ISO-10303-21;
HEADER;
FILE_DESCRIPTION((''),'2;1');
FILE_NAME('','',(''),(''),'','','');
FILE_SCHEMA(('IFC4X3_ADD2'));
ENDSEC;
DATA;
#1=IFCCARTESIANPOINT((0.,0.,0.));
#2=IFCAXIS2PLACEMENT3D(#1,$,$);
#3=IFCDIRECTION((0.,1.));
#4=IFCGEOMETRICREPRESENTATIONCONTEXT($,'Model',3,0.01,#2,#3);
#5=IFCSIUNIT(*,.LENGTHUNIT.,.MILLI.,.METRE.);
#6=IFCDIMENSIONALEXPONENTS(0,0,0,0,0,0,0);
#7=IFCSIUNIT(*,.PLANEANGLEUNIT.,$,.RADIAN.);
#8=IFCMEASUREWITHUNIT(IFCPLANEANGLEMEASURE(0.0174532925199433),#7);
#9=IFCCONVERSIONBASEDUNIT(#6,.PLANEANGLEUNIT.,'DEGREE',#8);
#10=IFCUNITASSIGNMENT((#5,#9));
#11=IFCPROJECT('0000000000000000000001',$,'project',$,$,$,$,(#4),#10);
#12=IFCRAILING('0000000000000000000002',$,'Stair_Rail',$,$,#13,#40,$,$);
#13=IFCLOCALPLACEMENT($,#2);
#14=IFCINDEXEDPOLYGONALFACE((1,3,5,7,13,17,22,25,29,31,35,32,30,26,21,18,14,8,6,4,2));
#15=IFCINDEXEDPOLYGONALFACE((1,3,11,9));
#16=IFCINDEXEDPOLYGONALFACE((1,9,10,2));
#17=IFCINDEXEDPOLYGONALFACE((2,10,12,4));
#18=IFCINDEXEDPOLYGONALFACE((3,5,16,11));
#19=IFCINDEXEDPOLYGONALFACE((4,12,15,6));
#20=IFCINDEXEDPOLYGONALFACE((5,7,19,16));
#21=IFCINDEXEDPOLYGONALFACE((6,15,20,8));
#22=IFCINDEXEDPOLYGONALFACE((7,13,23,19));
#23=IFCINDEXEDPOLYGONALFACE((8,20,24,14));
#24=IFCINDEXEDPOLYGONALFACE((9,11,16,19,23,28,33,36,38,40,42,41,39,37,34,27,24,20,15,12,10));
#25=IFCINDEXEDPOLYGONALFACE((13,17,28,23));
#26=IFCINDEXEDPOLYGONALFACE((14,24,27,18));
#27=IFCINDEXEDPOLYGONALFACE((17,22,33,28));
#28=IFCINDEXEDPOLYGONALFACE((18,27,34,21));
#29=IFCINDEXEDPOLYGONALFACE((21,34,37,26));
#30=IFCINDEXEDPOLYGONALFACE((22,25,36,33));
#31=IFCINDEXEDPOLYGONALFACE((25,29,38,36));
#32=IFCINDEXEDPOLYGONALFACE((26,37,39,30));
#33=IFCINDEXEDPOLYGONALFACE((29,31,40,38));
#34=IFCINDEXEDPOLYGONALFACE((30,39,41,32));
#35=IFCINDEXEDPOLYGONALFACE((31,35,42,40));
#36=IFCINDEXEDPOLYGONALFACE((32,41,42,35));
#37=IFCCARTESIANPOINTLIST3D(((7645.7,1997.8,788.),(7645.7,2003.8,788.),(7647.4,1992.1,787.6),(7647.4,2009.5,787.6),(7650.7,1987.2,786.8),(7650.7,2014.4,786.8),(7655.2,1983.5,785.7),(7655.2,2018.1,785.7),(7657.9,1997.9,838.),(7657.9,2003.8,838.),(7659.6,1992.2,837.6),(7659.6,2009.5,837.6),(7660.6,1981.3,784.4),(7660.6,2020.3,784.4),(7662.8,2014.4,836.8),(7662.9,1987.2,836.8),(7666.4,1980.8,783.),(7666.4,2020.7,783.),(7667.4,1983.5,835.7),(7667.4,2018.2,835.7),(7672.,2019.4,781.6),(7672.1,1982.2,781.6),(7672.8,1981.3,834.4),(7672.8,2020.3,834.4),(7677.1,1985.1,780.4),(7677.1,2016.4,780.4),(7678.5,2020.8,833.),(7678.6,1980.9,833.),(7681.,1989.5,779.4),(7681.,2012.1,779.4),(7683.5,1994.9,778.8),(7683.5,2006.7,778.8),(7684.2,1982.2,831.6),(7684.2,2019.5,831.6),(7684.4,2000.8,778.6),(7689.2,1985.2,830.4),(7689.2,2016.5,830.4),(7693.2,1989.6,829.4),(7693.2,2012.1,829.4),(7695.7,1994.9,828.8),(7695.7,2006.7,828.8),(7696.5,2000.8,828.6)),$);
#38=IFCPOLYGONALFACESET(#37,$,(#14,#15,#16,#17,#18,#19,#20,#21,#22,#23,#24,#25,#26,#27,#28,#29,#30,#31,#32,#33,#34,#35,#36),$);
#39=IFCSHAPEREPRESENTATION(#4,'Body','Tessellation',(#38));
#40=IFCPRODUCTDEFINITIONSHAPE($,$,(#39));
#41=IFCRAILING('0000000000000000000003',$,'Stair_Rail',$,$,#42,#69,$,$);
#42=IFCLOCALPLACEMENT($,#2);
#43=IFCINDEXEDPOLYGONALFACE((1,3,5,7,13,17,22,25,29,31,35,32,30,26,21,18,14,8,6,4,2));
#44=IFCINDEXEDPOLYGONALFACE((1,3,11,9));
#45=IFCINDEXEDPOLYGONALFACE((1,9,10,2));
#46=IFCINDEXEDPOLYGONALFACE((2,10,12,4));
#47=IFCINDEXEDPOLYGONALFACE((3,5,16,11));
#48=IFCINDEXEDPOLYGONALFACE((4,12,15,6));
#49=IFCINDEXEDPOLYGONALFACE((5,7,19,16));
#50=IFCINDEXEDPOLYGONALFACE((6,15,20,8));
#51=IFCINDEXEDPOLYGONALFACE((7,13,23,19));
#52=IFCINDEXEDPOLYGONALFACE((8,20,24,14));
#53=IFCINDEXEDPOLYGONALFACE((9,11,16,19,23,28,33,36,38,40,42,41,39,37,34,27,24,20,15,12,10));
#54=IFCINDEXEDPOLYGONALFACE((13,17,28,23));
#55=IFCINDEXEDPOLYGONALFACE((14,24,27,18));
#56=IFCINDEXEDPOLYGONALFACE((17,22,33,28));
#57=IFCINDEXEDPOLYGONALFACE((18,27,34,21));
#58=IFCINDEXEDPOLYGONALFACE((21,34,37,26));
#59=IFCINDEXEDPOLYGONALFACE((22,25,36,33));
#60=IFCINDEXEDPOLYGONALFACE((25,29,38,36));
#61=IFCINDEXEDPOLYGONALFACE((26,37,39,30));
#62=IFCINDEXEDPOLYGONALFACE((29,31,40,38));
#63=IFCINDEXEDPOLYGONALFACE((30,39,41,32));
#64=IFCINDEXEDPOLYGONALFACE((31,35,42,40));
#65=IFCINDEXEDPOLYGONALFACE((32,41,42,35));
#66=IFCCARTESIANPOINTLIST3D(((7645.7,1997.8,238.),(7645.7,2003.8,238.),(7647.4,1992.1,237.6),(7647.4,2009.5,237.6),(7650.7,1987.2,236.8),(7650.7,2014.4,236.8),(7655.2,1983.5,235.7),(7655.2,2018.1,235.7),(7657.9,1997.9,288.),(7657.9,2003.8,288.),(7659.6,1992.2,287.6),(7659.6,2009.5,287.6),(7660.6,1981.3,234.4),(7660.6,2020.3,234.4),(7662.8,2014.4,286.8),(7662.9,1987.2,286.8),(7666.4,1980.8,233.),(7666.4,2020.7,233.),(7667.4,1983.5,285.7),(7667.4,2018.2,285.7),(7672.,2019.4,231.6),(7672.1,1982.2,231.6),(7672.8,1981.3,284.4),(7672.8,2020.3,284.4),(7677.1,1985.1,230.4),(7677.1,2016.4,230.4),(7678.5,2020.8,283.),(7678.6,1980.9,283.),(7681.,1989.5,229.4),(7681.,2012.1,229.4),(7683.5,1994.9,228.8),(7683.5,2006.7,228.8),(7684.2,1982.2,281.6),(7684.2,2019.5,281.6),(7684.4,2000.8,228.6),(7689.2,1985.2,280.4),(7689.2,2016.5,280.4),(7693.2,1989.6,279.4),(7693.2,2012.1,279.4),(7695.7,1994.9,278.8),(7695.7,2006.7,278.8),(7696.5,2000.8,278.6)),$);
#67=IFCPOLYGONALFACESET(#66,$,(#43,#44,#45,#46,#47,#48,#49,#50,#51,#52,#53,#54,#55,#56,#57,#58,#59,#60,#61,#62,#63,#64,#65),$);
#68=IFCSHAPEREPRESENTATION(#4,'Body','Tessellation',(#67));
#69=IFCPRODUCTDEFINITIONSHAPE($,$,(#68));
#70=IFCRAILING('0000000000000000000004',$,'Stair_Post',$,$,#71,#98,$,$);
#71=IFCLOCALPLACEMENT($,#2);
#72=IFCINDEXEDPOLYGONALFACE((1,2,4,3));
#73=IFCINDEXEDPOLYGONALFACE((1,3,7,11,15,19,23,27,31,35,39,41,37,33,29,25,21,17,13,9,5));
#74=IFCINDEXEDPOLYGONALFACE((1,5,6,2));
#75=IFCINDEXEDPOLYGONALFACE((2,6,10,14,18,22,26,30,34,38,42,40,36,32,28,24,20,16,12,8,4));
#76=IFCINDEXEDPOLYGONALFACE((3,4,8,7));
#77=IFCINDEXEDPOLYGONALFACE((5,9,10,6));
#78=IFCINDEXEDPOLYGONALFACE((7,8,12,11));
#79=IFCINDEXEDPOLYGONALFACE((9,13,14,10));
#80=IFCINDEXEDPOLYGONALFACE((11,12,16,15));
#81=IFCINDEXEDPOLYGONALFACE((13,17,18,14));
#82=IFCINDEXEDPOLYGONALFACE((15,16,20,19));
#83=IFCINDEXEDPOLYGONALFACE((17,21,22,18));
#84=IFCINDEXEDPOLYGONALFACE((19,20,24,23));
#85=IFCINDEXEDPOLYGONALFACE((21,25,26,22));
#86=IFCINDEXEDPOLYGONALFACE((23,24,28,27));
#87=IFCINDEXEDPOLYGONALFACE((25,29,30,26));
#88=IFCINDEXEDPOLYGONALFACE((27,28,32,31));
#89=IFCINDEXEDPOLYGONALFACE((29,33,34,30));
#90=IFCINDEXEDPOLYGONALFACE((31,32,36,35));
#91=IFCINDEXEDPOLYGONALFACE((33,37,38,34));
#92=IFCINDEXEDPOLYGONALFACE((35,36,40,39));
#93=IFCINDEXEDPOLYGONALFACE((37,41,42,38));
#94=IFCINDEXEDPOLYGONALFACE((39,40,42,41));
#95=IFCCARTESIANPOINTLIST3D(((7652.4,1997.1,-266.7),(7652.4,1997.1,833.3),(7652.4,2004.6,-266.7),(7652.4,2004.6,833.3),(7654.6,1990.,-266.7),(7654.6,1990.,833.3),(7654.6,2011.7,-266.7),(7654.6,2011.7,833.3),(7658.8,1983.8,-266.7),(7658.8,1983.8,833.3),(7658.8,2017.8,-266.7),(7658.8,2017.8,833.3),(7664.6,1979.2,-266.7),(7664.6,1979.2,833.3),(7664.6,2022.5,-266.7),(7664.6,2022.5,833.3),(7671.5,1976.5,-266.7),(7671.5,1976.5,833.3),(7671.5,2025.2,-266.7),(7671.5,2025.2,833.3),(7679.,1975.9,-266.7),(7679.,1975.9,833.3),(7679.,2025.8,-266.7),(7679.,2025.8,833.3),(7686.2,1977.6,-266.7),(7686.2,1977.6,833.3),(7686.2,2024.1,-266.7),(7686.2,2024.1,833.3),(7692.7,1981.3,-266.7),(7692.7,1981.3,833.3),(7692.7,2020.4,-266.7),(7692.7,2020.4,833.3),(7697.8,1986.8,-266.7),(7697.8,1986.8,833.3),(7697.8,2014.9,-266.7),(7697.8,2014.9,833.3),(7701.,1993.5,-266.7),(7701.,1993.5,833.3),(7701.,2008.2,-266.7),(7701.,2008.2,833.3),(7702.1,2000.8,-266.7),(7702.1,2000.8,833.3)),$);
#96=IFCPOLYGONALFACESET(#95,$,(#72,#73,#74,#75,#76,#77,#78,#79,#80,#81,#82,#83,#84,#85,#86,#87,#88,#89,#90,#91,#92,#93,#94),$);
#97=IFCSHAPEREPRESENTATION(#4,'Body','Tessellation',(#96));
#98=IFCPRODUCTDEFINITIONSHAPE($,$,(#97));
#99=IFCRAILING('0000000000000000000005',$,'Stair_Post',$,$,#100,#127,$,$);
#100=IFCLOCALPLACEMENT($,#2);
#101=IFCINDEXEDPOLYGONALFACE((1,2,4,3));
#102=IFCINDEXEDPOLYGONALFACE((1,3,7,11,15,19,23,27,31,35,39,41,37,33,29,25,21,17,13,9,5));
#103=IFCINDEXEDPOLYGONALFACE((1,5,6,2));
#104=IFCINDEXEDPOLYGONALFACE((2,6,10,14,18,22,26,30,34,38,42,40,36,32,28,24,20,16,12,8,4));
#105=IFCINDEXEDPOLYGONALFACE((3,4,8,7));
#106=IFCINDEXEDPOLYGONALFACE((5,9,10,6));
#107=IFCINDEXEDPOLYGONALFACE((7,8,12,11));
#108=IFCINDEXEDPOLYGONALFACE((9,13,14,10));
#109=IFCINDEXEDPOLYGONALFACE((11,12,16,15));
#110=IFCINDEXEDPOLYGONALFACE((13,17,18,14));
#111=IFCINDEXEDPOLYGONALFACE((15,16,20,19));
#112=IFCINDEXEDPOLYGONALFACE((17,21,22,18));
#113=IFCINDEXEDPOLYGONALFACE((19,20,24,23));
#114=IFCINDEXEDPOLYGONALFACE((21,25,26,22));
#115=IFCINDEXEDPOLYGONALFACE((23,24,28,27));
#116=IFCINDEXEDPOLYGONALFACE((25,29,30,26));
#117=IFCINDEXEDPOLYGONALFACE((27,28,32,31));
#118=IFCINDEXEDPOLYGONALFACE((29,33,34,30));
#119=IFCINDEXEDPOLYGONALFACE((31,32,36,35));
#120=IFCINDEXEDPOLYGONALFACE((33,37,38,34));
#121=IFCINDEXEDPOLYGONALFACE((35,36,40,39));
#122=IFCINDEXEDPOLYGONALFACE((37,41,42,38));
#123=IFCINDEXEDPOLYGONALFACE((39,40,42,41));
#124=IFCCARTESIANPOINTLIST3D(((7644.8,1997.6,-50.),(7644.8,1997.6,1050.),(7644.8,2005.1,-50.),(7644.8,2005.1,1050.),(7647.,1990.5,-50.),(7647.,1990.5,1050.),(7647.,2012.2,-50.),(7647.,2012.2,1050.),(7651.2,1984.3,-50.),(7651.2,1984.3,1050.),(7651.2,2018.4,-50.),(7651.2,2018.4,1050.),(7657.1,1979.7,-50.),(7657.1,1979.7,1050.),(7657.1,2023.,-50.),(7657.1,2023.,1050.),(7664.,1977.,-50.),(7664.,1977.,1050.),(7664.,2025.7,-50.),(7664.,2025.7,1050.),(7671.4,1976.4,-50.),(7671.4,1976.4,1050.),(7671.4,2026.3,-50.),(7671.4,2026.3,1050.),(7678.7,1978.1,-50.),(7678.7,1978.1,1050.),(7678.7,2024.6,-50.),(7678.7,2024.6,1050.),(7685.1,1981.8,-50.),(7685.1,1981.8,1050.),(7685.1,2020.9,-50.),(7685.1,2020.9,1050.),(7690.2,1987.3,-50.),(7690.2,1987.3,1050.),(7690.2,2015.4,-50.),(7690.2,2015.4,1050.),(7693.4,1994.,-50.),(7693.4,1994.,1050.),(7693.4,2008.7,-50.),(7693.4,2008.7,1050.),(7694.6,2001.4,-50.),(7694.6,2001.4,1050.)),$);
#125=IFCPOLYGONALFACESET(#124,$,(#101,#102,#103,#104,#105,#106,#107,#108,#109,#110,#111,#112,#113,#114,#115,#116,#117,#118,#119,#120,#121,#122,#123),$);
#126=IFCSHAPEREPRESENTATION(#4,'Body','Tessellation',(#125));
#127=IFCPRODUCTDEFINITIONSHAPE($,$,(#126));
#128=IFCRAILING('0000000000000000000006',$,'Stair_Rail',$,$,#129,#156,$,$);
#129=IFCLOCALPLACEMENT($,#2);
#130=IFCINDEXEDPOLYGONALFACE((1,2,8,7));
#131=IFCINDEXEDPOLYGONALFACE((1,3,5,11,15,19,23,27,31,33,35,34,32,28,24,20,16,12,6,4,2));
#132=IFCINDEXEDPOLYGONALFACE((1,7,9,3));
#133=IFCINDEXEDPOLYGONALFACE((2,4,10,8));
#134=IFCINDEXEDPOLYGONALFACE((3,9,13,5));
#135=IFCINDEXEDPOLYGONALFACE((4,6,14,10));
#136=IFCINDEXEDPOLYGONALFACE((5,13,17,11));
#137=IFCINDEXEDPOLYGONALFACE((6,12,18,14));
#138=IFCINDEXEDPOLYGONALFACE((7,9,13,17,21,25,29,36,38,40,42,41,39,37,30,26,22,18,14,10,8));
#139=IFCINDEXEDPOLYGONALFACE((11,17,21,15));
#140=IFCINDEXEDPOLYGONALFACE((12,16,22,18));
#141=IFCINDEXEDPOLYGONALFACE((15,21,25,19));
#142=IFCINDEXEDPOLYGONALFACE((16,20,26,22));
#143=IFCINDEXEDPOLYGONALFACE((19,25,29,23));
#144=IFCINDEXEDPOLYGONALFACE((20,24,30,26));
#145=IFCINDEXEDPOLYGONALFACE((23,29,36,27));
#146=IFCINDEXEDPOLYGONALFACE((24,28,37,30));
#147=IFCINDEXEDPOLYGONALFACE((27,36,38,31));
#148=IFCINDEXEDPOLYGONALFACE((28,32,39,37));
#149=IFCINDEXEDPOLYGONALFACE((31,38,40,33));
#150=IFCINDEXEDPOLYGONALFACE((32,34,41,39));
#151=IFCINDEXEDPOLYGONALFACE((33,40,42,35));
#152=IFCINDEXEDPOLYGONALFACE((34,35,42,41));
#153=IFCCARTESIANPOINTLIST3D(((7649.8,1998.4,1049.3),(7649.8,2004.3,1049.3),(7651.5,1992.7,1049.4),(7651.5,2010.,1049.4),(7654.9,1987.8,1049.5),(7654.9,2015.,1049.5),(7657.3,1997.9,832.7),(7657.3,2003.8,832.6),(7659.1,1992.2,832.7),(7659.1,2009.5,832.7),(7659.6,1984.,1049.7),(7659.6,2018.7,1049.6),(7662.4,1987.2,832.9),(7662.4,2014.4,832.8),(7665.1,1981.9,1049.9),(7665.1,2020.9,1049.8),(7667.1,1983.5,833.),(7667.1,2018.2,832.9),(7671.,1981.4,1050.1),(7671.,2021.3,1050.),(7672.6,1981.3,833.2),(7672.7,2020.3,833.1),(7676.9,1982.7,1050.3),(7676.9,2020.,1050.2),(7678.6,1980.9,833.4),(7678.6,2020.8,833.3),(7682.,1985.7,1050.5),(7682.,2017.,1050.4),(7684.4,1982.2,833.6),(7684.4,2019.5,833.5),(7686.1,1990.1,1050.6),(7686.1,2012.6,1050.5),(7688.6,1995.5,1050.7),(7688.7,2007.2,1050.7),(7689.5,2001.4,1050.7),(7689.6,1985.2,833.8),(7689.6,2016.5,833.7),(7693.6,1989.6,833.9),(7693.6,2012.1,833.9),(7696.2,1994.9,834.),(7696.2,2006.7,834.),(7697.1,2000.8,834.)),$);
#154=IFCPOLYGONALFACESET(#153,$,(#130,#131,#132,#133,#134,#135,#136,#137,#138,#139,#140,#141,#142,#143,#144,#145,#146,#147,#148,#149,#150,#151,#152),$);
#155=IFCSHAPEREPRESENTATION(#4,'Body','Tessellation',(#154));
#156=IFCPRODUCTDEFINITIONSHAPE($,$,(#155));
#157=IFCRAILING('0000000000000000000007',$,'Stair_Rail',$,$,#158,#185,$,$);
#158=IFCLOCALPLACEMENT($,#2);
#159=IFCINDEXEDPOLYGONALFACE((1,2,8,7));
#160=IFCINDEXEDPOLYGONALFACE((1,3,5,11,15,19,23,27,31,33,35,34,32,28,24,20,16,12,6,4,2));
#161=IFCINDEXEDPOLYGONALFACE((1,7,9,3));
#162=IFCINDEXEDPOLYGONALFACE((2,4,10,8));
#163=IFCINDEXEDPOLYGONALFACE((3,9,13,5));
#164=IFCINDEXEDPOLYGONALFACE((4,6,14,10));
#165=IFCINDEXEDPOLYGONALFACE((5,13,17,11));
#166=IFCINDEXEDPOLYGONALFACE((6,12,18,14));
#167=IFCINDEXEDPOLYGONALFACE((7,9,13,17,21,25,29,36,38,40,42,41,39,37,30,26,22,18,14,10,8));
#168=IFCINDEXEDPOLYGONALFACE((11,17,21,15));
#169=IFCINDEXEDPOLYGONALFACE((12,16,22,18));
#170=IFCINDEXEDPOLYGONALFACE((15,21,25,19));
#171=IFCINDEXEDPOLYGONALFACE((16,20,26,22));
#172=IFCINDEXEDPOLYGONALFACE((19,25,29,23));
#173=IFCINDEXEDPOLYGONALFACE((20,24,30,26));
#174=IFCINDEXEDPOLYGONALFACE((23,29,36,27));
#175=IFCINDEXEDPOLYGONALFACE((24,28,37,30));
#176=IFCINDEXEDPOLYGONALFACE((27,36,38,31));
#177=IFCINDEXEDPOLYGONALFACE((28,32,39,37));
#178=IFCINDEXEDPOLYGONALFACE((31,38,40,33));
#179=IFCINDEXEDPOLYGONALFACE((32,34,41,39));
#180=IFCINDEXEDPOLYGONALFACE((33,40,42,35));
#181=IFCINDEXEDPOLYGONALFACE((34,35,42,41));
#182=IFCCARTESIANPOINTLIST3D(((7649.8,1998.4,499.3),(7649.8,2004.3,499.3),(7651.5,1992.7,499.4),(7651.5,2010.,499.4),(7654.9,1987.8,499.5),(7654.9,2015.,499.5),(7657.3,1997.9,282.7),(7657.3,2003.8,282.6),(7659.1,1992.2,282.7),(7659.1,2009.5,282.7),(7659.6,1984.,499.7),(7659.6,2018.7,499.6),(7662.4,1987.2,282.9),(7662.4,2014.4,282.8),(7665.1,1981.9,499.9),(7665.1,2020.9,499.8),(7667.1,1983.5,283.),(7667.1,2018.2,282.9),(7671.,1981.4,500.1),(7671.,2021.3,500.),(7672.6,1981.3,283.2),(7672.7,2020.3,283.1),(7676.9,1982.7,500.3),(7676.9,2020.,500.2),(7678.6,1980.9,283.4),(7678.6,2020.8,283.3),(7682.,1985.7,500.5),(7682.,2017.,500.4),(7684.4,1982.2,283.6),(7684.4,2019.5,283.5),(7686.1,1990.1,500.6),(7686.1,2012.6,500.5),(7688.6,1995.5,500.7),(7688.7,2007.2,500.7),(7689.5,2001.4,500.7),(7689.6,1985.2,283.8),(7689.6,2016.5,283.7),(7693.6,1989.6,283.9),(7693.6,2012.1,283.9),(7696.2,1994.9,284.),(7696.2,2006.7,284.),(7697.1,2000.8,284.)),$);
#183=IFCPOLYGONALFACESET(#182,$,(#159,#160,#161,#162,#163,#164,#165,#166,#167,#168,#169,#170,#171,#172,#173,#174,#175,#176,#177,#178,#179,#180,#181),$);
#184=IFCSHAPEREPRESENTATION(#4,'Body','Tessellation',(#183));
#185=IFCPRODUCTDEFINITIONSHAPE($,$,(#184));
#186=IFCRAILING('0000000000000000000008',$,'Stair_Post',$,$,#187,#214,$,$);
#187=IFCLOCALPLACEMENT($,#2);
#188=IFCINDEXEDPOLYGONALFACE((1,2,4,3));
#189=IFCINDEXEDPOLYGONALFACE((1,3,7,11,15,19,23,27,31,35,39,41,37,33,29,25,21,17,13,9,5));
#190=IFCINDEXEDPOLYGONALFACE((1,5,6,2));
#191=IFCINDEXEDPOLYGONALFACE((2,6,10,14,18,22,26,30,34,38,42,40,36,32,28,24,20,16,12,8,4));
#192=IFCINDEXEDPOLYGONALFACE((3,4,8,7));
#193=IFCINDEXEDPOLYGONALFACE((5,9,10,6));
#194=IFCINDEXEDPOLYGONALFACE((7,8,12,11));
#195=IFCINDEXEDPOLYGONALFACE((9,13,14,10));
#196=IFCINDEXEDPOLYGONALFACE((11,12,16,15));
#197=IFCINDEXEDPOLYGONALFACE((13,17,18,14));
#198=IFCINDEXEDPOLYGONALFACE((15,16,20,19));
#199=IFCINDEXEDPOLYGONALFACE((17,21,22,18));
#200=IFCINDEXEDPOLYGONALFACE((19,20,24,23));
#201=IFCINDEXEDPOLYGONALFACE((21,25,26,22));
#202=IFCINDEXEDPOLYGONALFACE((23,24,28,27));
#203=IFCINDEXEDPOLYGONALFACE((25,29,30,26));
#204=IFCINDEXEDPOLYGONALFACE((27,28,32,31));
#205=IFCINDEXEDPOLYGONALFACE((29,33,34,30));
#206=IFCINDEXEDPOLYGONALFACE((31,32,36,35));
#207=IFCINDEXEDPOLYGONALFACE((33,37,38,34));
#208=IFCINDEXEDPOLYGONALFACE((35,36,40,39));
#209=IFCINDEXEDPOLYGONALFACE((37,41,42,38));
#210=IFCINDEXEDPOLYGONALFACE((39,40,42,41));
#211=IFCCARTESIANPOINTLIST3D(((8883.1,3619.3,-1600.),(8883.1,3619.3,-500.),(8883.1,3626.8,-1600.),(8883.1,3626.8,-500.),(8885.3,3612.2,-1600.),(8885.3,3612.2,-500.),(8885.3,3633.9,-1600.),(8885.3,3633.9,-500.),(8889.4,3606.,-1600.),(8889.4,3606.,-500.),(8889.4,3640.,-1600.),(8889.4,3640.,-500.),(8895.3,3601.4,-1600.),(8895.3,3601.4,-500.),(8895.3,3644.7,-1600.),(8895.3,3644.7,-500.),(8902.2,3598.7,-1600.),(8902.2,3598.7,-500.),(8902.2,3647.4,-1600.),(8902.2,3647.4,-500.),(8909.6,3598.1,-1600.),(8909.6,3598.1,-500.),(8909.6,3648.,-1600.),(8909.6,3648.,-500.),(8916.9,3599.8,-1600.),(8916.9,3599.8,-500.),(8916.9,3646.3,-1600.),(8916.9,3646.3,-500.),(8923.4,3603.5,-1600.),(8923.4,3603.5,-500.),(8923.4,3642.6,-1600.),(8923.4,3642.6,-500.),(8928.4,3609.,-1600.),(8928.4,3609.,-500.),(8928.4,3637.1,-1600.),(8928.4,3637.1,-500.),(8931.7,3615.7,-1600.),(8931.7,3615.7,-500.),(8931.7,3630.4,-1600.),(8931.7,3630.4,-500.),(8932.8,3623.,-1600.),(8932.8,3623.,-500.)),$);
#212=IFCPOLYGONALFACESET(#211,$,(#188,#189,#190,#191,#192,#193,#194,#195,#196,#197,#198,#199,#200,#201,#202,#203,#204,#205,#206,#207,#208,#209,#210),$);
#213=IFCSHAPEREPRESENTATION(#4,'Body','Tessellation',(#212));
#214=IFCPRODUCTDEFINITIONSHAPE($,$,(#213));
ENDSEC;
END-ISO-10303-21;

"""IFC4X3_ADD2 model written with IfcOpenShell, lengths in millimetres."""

from ifc_helpers import new_model, entity, si_unit, converted_unit, direction, frame, origin, context, project, circle, extrude, element, save


model = new_model("IFC4X3_ADD2")

# Units and contexts
model_context = context("Model", 3, precision=0.01, world=origin(), true_north=direction((0.0, 1.0)))
ifc_project = project(units=[si_unit("LENGTHUNIT", "METRE", prefix="MILLI"), converted_unit("PLANEANGLEUNIT", "DEGREE", entity("IfcPlaneAngleMeasure", 0.0174532925199433), si_unit("PLANEANGLEUNIT", "RADIAN"), dimensions=[0, 0, 0, 0, 0, 0, 0])], contexts=[model_context])

# Railings
element("IfcRailing", 1, Name="Stair_Rail", context=model_context, shape_type="SweptSolid", body=[
    entity("IfcSweptDiskSolid", entity("IfcPolyline", [entity("IfcCartesianPoint", [7664.9, 2000.8, 783.3]), entity("IfcCartesianPoint", [7677.1, 2000.8, 833.3])]), 20.0),
])
element("IfcRailing", 2, Name="Stair_Rail", context=model_context, shape_type="SweptSolid", body=[
    entity("IfcSweptDiskSolid", entity("IfcPolyline", [entity("IfcCartesianPoint", [7664.9, 2000.8, 233.3]), entity("IfcCartesianPoint", [7677.1, 2000.8, 283.3])]), 20.0),
])
element("IfcRailing", 3, Name="Stair_Post", context=model_context, shape_type="SweptSolid", body=[
    extrude(circle(Radius=25.0), frame((7677.1, 2000.8, -266.7)), (0.0, 0.0, 1.0), 1100.0),
])
element("IfcRailing", 4, Name="Stair_Post", context=model_context, shape_type="SweptSolid", body=[
    extrude(circle(Radius=25.0), frame((7669.6, 2001.4, -50.0)), (0.0, 0.0, 1.0), 1100.0),
])
element("IfcRailing", 5, Name="Stair_Rail", context=model_context, shape_type="SweptSolid", body=[
    entity("IfcSweptDiskSolid", entity("IfcPolyline", [entity("IfcCartesianPoint", [7677.1, 2000.8, 833.3]), entity("IfcCartesianPoint", [7669.6, 2001.4, 1050.0])]), 20.0),
])
element("IfcRailing", 6, Name="Stair_Rail", context=model_context, shape_type="SweptSolid", body=[
    entity("IfcSweptDiskSolid", entity("IfcPolyline", [entity("IfcCartesianPoint", [7677.1, 2000.8, 283.3]), entity("IfcCartesianPoint", [7669.6, 2001.4, 500.0])]), 20.0),
])
element("IfcRailing", 7, Name="Stair_Post", context=model_context, shape_type="SweptSolid", body=[
    extrude(circle(Radius=25.0), frame((8907.8, 3623.0, -1600.0)), (0.0, 0.0, 1.0), 1100.0),
])

save(model, "model.ifc")
